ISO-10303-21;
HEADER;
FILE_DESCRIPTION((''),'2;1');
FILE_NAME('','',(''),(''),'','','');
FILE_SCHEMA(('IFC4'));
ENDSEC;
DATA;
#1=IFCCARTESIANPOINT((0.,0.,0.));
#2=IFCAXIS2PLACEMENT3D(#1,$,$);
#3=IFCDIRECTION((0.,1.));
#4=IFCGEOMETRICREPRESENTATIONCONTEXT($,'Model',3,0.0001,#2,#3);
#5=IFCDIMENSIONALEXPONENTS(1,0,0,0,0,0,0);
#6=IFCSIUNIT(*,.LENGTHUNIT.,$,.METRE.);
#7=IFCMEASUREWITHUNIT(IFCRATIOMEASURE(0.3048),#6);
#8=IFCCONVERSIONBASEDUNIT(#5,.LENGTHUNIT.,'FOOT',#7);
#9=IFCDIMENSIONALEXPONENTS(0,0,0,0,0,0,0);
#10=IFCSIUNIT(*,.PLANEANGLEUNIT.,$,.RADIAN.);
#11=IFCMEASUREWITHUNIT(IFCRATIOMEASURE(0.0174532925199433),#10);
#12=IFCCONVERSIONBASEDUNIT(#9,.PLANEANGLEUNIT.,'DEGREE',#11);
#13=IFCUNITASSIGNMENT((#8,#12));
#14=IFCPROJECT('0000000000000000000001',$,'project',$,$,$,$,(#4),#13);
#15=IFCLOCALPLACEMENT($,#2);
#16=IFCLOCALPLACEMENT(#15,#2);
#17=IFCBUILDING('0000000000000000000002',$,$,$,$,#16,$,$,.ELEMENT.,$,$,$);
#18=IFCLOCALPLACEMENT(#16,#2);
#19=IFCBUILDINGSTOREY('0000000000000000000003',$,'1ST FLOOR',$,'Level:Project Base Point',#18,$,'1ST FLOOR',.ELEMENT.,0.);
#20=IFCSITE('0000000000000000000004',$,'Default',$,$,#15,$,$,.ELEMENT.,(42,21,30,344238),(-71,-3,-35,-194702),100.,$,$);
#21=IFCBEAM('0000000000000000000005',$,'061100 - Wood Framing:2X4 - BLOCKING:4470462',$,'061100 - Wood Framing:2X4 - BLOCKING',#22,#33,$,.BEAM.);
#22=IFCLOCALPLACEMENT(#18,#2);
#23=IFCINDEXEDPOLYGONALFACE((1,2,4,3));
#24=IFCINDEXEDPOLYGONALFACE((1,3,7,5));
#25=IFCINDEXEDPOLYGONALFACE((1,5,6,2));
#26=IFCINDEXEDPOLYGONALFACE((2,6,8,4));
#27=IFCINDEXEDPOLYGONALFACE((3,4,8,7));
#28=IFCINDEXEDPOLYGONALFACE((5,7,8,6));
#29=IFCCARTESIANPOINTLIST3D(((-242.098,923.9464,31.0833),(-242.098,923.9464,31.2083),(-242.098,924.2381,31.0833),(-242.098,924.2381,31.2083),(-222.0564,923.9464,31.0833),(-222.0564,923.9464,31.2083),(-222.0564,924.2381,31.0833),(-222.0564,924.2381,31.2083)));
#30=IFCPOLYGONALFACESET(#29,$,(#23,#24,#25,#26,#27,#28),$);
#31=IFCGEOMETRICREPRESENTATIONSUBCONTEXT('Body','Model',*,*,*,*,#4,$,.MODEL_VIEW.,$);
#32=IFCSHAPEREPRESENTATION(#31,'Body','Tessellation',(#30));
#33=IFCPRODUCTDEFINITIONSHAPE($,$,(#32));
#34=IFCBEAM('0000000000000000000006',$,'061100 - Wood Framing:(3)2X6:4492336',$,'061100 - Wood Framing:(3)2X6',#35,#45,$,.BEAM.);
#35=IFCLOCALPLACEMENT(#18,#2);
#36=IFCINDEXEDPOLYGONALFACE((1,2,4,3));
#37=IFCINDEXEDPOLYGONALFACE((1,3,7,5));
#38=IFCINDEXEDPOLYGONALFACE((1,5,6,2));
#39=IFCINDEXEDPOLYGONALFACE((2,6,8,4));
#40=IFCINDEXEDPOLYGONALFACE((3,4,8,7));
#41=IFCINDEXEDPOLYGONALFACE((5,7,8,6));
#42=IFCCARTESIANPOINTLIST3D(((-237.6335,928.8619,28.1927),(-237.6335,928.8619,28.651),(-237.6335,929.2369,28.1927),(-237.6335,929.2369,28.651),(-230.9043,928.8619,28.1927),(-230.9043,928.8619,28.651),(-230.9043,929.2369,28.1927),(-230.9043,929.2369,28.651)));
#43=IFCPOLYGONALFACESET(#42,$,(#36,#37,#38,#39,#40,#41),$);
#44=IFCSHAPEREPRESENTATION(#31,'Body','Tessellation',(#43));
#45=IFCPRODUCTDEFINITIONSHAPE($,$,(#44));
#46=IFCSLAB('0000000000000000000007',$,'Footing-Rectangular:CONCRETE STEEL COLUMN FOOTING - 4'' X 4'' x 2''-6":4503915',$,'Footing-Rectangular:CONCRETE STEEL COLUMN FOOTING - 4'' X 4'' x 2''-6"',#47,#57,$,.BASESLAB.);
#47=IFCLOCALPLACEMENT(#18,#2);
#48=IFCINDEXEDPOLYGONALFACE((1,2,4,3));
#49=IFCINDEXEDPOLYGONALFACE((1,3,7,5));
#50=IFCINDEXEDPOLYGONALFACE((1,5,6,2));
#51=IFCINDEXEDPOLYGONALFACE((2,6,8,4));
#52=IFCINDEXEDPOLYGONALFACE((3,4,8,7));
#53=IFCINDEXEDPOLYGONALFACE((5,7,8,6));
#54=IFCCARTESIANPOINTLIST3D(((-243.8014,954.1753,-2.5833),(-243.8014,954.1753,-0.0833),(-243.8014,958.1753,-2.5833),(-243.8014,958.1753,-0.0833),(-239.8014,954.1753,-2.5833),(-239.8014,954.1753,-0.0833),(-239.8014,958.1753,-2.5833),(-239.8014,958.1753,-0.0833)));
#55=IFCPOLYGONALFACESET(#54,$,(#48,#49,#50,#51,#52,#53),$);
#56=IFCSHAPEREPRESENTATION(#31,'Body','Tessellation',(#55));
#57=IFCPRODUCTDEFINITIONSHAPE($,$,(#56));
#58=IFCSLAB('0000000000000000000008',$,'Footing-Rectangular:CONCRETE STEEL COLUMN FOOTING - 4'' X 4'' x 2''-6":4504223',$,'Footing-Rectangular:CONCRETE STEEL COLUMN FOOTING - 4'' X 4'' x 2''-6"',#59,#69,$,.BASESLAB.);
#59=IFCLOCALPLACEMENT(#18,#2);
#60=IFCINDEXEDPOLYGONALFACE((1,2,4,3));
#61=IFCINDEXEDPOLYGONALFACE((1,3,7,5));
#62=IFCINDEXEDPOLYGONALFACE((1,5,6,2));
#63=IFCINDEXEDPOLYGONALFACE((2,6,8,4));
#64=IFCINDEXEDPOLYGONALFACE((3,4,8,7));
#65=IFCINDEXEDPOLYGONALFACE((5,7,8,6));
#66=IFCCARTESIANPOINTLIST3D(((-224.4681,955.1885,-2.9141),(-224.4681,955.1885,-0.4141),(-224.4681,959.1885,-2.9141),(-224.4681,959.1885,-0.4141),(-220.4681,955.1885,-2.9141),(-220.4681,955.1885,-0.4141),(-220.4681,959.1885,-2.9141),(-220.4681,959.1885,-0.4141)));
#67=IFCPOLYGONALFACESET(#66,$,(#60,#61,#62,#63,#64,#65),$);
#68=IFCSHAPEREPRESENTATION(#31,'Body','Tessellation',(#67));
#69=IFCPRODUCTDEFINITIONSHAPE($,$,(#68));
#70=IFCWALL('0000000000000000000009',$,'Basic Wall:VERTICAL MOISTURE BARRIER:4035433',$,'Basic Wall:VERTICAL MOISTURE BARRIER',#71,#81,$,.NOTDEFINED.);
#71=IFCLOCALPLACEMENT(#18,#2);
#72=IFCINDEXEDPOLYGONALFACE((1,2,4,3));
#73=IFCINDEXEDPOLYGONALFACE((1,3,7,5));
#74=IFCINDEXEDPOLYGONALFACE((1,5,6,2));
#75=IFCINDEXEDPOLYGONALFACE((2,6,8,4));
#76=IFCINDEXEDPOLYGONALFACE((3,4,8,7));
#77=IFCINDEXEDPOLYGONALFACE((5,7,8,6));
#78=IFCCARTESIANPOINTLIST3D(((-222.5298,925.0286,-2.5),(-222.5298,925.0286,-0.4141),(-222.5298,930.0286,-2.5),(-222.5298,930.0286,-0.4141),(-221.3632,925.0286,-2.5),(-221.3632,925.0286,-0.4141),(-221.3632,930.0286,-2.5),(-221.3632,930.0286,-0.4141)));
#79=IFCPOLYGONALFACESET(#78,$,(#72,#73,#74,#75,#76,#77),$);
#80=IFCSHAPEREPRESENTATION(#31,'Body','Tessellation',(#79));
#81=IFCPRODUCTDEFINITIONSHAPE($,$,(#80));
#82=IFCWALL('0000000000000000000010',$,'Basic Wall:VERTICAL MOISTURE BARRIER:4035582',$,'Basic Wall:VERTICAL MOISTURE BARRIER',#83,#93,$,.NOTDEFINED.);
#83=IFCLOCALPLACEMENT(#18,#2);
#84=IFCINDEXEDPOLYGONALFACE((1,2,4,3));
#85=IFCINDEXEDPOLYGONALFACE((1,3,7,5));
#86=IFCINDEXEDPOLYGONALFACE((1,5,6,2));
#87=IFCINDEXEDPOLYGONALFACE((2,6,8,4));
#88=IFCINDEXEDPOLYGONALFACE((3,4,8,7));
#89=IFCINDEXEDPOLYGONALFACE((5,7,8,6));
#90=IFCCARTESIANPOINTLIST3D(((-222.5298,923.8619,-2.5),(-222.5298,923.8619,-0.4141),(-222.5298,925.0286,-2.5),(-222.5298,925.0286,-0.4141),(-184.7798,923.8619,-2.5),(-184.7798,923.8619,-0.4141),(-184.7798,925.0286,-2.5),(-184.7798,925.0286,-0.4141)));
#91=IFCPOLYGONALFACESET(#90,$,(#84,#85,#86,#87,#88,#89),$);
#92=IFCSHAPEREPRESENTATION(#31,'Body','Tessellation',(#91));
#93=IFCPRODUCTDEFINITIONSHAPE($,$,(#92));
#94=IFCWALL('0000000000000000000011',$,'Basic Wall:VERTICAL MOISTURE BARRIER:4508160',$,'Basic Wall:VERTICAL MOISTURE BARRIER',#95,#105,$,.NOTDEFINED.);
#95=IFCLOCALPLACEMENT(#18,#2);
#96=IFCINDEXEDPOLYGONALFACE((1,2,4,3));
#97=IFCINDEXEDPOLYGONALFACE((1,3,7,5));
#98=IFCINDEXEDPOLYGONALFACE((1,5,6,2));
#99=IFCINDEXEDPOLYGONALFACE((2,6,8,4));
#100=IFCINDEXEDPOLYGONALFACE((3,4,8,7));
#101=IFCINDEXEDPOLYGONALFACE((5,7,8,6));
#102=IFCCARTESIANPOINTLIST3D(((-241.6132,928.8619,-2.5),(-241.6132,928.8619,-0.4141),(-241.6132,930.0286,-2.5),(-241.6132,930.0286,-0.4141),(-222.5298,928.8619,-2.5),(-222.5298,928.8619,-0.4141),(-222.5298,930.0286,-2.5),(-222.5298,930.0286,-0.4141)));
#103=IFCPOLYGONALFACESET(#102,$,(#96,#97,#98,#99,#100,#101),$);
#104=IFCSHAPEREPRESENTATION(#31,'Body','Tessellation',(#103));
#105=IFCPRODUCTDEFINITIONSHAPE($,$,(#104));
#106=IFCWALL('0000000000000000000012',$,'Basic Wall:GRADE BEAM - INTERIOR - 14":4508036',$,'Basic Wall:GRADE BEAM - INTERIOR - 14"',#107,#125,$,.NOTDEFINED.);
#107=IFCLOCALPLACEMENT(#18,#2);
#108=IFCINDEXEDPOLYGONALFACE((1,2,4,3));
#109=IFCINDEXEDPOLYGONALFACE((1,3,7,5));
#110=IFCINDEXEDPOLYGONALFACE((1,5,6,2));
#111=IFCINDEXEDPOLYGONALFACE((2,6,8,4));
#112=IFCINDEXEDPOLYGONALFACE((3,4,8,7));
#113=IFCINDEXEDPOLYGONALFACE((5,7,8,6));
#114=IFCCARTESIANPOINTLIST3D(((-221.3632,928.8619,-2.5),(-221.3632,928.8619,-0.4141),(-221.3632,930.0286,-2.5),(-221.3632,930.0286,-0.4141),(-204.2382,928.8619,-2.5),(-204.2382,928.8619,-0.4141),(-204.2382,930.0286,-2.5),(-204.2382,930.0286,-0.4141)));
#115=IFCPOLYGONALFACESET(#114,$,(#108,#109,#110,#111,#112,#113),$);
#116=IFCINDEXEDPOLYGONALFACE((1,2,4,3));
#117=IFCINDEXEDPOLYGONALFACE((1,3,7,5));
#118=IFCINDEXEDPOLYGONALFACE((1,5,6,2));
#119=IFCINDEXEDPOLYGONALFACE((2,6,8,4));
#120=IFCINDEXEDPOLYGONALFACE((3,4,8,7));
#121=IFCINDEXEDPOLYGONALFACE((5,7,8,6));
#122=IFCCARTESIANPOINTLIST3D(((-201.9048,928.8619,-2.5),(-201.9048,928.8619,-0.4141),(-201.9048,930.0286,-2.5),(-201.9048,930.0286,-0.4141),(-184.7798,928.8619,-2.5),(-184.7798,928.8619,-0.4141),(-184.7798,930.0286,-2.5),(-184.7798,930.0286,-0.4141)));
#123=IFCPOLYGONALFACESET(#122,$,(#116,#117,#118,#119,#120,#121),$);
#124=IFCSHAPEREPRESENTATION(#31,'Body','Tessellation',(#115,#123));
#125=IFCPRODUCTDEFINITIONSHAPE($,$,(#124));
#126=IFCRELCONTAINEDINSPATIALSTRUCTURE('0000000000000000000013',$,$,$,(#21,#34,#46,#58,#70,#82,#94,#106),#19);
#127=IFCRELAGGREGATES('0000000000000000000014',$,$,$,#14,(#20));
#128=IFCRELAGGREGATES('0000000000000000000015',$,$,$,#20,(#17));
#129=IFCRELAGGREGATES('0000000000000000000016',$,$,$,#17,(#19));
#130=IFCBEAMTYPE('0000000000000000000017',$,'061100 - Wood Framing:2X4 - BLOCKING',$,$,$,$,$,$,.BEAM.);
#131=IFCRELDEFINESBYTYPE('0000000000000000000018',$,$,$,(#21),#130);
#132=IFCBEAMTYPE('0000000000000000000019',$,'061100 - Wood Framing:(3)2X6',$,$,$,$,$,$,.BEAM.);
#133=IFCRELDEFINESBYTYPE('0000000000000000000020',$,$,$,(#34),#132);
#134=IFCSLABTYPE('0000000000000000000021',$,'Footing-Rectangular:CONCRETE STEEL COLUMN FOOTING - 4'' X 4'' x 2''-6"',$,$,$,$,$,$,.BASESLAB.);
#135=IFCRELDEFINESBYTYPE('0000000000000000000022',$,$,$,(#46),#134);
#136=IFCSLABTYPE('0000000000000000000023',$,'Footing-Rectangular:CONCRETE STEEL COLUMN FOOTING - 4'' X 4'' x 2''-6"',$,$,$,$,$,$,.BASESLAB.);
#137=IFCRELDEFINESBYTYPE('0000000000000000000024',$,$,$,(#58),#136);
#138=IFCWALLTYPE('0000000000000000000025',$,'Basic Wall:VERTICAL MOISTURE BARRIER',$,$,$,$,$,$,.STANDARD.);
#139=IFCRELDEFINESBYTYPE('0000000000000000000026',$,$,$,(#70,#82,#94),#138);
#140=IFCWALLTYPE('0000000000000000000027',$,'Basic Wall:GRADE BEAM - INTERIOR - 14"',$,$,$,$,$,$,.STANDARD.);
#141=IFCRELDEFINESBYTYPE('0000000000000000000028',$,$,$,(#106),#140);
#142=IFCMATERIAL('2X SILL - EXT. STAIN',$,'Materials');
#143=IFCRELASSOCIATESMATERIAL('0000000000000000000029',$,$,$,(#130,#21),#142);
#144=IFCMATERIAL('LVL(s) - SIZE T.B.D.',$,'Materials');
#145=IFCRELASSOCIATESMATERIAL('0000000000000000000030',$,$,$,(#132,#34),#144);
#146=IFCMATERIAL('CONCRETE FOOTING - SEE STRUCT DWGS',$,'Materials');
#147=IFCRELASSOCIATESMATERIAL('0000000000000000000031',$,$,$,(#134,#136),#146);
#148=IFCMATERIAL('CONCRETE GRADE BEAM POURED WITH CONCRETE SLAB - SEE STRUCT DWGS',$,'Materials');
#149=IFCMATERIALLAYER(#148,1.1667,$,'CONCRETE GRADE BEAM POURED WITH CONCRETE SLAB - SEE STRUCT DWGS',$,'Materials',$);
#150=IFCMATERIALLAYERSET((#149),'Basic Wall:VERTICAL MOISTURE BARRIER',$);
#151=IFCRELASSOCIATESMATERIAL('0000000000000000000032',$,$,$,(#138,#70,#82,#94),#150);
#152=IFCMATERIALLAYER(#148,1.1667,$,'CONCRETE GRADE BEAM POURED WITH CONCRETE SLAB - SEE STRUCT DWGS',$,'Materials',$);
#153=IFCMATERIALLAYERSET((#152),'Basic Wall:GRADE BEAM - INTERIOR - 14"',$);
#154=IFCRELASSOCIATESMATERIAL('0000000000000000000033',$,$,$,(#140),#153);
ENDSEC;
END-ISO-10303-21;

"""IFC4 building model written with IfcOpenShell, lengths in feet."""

from ifc_helpers import new_model, entity, si_unit, converted_unit, direction, frame, frame_2d, origin, origin_2d_with_axis, place, context, subcontext, project, spatial, polyline, rectangle, extrude, clip, bounded_halfspace, source, transform, mapped, material, layer, layer_set, layer_usage, material_profile, profile_set, profile_usage, type_object, type_shapes, element, save


model = new_model("IFC4")

# Units and contexts
model_context = context("Model", 3, precision=0.0001, world=origin(), true_north=direction((0.0, 1.0)))
body_context = subcontext(model_context, "Body", "Model", "MODEL_VIEW")
ifc_project = project(units=[converted_unit("LENGTHUNIT", "FOOT", entity("IfcRatioMeasure", 0.3048), si_unit("LENGTHUNIT", "METRE"), dimensions=[1, 0, 0, 0, 0, 0, 0]), converted_unit("PLANEANGLEUNIT", "DEGREE", entity("IfcRatioMeasure", 0.0174532925199433), si_unit("PLANEANGLEUNIT", "RADIAN"), dimensions=[0, 0, 0, 0, 0, 0, 0])], contexts=[model_context])

# Site, building, storey
site_placement = place(None, origin())
site = spatial("IfcSite", under=ifc_project, at=site_placement, Name="Default", CompositionType="ELEMENT", RefLatitude=(42, 21, 30, 344238), RefLongitude=(-71, -3, -35, -194702), RefElevation=100.0)
building_placement = place(site_placement, origin())
building = spatial("IfcBuilding", under=site, at=building_placement, CompositionType="ELEMENT")
storey_placement = place(building_placement, origin())
storey = spatial("IfcBuildingStorey", under=building, at=storey_placement, Name="1ST FLOOR", ObjectType="Level:Project Base Point", LongName="1ST FLOOR", CompositionType="ELEMENT", Elevation=0.0)

# Beams
ifc_material_1 = material(Name="LVL(s) - SIZE T.B.D.", Category="Materials")
ifc_material_profile_1 = material_profile(ifc_material_1, rectangle(XDim=0.4583, YDim=0.375, at=frame_2d((0.0, 0.0), x_axis=(1.0, 0.0))), Name="(3)2X6")
ifc_profile_set_1 = profile_set([ifc_material_profile_1], Name="(3)2X6")
ifc_material_2 = material(Name="2X SILL - EXT. STAIN", Category="Materials")
ifc_material_profile_2 = material_profile(ifc_material_2, rectangle(XDim=0.125, YDim=0.2917, at=origin_2d_with_axis()), Name="2X4 - BLOCKING")
ifc_profile_set_2 = profile_set([ifc_material_profile_2], Name="2X4 - BLOCKING")
ifc_profile_usage_1 = profile_usage(ifc_profile_set_2, cardinal=8)
beam_type_1 = type_object("IfcBeamType", Name="061100 - Wood Framing:2X4 - BLOCKING", PredefinedType="BEAM", material=ifc_profile_set_2)
shared_shape_1 = source(origin(), body_context, "Body", "SweptSolid", [
    extrude(rectangle(XDim=0.125, YDim=0.2917, at=frame_2d((0.0, 0.0), x_axis=(1.0, 0.0))), frame((-10.0208, 0.0, 0.0), z_axis=(1.0, 0.0, 0.0), x_axis=(0.0, 0.0, -1.0)), (0.0, 0.0, 1.0), 20.0417),
])
type_shapes(beam_type_1, [shared_shape_1])
beam_1_placement = place(storey_placement, frame((-232.0772, 924.0922, 31.1458)))
element("IfcBeam", 1, at=beam_1_placement, inside=storey, type_object=beam_type_1, material=ifc_profile_usage_1, Name="061100 - Wood Framing:2X4 - BLOCKING:4470462", ObjectType="061100 - Wood Framing:2X4 - BLOCKING", PredefinedType="BEAM", context=body_context, shape_type="MappedRepresentation", body=[
    mapped(shared_shape_1, transform((0.0, 0.0, 0.0), scale=1.0)),
])
ifc_profile_usage_2 = profile_usage(ifc_profile_set_1, cardinal=8)
beam_type_2 = type_object("IfcBeamType", Name="061100 - Wood Framing:(3)2X6", PredefinedType="BEAM", material=ifc_profile_set_1)
shared_shape_2 = source(origin(), body_context, "Body", "SweptSolid", [
    extrude(rectangle(XDim=0.4583, YDim=0.375, at=frame_2d((0.0, 0.0), x_axis=(1.0, 0.0))), frame((-3.3795, 0.0, 0.0), z_axis=(1.0, 0.0, 0.0), x_axis=(0.0, 0.0, -1.0)), (0.0, 0.0, 1.0), 6.7292),
])
type_shapes(beam_type_2, [shared_shape_2])
beam_2_placement = place(storey_placement, frame((-234.254, 929.0494, 28.4219)))
element("IfcBeam", 2, at=beam_2_placement, inside=storey, type_object=beam_type_2, material=ifc_profile_usage_2, Name="061100 - Wood Framing:(3)2X6:4492336", ObjectType="061100 - Wood Framing:(3)2X6", PredefinedType="BEAM", context=body_context, shape_type="MappedRepresentation", body=[
    mapped(shared_shape_2, transform((0.0, 0.0, 0.0), scale=1.0)),
])

# Slabs
ifc_material_3 = material(Name="CONCRETE FOOTING - SEE STRUCT DWGS", Category="Materials")
slab_type_1 = type_object("IfcSlabType", Name="Footing-Rectangular:CONCRETE STEEL COLUMN FOOTING - 4' X 4' x 2'-6\"", PredefinedType="BASESLAB", material=ifc_material_3)
slab_1_placement = place(storey_placement, frame((-243.8014, 954.1753, -2.5833)))
element("IfcSlab", 3, at=slab_1_placement, inside=storey, type_object=slab_type_1, Name="Footing-Rectangular:CONCRETE STEEL COLUMN FOOTING - 4' X 4' x 2'-6\":4503915", ObjectType="Footing-Rectangular:CONCRETE STEEL COLUMN FOOTING - 4' X 4' x 2'-6\"", PredefinedType="BASESLAB", context=body_context, shape_type="SweptSolid", body=[
    extrude(rectangle(XDim=4.0, YDim=4.0, at=frame_2d((0.0, 0.0), x_axis=(1.0, 0.0))), frame((2.0, 2.0, 0.0), z_axis=(0.0, 0.0, 1.0), x_axis=(-1.0, 0.0, 0.0)), (0.0, 0.0, 1.0), 2.5),
])
slab_type_2 = type_object("IfcSlabType", Name="Footing-Rectangular:CONCRETE STEEL COLUMN FOOTING - 4' X 4' x 2'-6\"", PredefinedType="BASESLAB", material=ifc_material_3)
slab_2_placement = place(storey_placement, frame((-224.4681, 955.1885, -2.9141)))
element("IfcSlab", 4, at=slab_2_placement, inside=storey, type_object=slab_type_2, Name="Footing-Rectangular:CONCRETE STEEL COLUMN FOOTING - 4' X 4' x 2'-6\":4504223", ObjectType="Footing-Rectangular:CONCRETE STEEL COLUMN FOOTING - 4' X 4' x 2'-6\"", PredefinedType="BASESLAB", context=body_context, shape_type="SweptSolid", body=[
    extrude(rectangle(XDim=4.0, YDim=4.0, at=frame_2d((0.0, 0.0), x_axis=(1.0, 0.0))), frame((2.0, 2.0, 0.0), z_axis=(0.0, 0.0, 1.0), x_axis=(-1.0, 0.0, 0.0)), (0.0, 0.0, 1.0), 2.5),
])

# Walls
ifc_material_4 = material(Name="CONCRETE GRADE BEAM POURED WITH CONCRETE SLAB - SEE STRUCT DWGS", Category="Materials")
ifc_layer_1 = layer(ifc_material_4, 1.1667, Name="CONCRETE GRADE BEAM POURED WITH CONCRETE SLAB - SEE STRUCT DWGS", Category="Materials")
ifc_layer_set_1 = layer_set([ifc_layer_1], Name="Basic Wall:VERTICAL MOISTURE BARRIER")
ifc_layer_usage_1 = layer_usage(ifc_layer_set_1, "AXIS2", "NEGATIVE", 0.5833)
wall_type_1 = type_object("IfcWallType", Name="Basic Wall:VERTICAL MOISTURE BARRIER", PredefinedType="STANDARD", material=ifc_layer_set_1)
wall_1_placement = place(storey_placement, frame((-221.9465, 925.0286, -2.5), z_axis=(0.0, 0.0, 1.0), x_axis=(0.0, 1.0, 0.0)))
element("IfcWall", 5, at=wall_1_placement, inside=storey, type_object=wall_type_1, material=ifc_layer_usage_1, Name="Basic Wall:VERTICAL MOISTURE BARRIER:4035433", ObjectType="Basic Wall:VERTICAL MOISTURE BARRIER", PredefinedType="NOTDEFINED", context=body_context, shape_type="Clipping", body=[
    clip(extrude(rectangle(XDim=5.0, YDim=1.1667, at=frame_2d((2.5, 0.0), x_axis=(-1.0, 0.0))), origin(), (0.0, 0.0, 1.0), 2.0859), bounded_halfspace(frame((0.0, -0.5833, 2.0859), z_axis=(0.0, 0.0, -1.0), x_axis=(0.0, -1.0, 0.0)), True, frame((0.0, -0.5833, 2.0859)), polyline([(0.0, 0.0), (5.0, 0.0), (5.0, 1.1667), (3.8333, 1.1667), (0.0, 1.1667), (0.0, 0.0)]))),
])
ifc_layer_usage_2 = layer_usage(ifc_layer_set_1, "AXIS2", "POSITIVE", -0.5833)
wall_2_placement = place(storey_placement, frame((-222.5298, 924.4453, -2.5)))
element("IfcWall", 6, at=wall_2_placement, inside=storey, type_object=wall_type_1, material=ifc_layer_usage_2, Name="Basic Wall:VERTICAL MOISTURE BARRIER:4035582", ObjectType="Basic Wall:VERTICAL MOISTURE BARRIER", PredefinedType="NOTDEFINED", context=body_context, shape_type="Clipping", body=[
    clip(extrude(rectangle(XDim=37.75, YDim=1.1667, at=frame_2d((18.875, 0.0), x_axis=(-1.0, 0.0))), origin(), (0.0, 0.0, 1.0), 2.0859), bounded_halfspace(frame((0.0, -0.5833, 2.0859), z_axis=(0.0, 0.0, -1.0), x_axis=(1.0, 0.0, 0.0)), True, frame((0.0, -0.5833, 2.0859)), polyline([(0.0, 0.0), (37.75, 0.0), (37.75, 1.1667), (29.7083, 1.1667), (28.5417, 1.1667), (20.625, 1.1667), (18.2917, 1.1667), (10.375, 1.1667), (9.2083, 1.1667), (1.1667, 1.1667), (0.0, 1.1667), (0.0, 0.0)]))),
])
ifc_layer_usage_3 = layer_usage(ifc_layer_set_1, "AXIS2", "POSITIVE", -0.5833)
wall_3_placement = place(storey_placement, frame((-241.6132, 929.4453, -2.5)))
element("IfcWall", 7, at=wall_3_placement, inside=storey, type_object=wall_type_1, material=ifc_layer_usage_3, Name="Basic Wall:VERTICAL MOISTURE BARRIER:4508160", ObjectType="Basic Wall:VERTICAL MOISTURE BARRIER", PredefinedType="NOTDEFINED", context=body_context, shape_type="Clipping", body=[
    clip(extrude(rectangle(XDim=19.0833, YDim=1.1667, at=frame_2d((9.5417, 0.0), x_axis=(-1.0, 0.0))), origin(), (0.0, 0.0, 1.0), 2.0859), bounded_halfspace(frame((0.0, -0.5833, 2.0859), z_axis=(0.0, 0.0, -1.0), x_axis=(1.0, 0.0, 0.0)), True, frame((0.0, -0.5833, 2.0859)), polyline([(0.0, 0.0), (19.0833, 0.0), (19.0833, 1.1667), (18.0417, 1.1667), (10.125, 1.1667), (8.9583, 1.1667), (0.0, 1.1667), (0.0, 0.0)]))),
])
ifc_layer_2 = layer(ifc_material_4, 1.1667, Name="CONCRETE GRADE BEAM POURED WITH CONCRETE SLAB - SEE STRUCT DWGS", Category="Materials")
ifc_layer_set_2 = layer_set([ifc_layer_2], Name="Basic Wall:GRADE BEAM - INTERIOR - 14\"")
wall_type_2 = type_object("IfcWallType", Name="Basic Wall:GRADE BEAM - INTERIOR - 14\"", PredefinedType="STANDARD", material=ifc_layer_set_2)
wall_4_placement = place(storey_placement, frame((-221.3632, 929.4453, -2.5)))
element("IfcWall", 8, at=wall_4_placement, inside=storey, type_object=wall_type_2, Name="Basic Wall:GRADE BEAM - INTERIOR - 14\":4508036", ObjectType="Basic Wall:GRADE BEAM - INTERIOR - 14\"", PredefinedType="NOTDEFINED", context=body_context, shape_type="SweptSolid", body=[
    extrude(rectangle(XDim=17.125, YDim=1.1667, at=frame_2d((0.0, 0.0), x_axis=(1.0, 0.0))), frame((8.5625, 0.0, 0.0)), (0.0, 0.0, 1.0), 2.0859),
    extrude(rectangle(XDim=17.125, YDim=1.1667, at=origin_2d_with_axis()), frame((28.0208, 0.0, 0.0), z_axis=(0.0, 0.0, 1.0), x_axis=(-1.0, 0.0, 0.0)), (0.0, 0.0, 1.0), 2.0859),
])

save(model, "model.ifc")
